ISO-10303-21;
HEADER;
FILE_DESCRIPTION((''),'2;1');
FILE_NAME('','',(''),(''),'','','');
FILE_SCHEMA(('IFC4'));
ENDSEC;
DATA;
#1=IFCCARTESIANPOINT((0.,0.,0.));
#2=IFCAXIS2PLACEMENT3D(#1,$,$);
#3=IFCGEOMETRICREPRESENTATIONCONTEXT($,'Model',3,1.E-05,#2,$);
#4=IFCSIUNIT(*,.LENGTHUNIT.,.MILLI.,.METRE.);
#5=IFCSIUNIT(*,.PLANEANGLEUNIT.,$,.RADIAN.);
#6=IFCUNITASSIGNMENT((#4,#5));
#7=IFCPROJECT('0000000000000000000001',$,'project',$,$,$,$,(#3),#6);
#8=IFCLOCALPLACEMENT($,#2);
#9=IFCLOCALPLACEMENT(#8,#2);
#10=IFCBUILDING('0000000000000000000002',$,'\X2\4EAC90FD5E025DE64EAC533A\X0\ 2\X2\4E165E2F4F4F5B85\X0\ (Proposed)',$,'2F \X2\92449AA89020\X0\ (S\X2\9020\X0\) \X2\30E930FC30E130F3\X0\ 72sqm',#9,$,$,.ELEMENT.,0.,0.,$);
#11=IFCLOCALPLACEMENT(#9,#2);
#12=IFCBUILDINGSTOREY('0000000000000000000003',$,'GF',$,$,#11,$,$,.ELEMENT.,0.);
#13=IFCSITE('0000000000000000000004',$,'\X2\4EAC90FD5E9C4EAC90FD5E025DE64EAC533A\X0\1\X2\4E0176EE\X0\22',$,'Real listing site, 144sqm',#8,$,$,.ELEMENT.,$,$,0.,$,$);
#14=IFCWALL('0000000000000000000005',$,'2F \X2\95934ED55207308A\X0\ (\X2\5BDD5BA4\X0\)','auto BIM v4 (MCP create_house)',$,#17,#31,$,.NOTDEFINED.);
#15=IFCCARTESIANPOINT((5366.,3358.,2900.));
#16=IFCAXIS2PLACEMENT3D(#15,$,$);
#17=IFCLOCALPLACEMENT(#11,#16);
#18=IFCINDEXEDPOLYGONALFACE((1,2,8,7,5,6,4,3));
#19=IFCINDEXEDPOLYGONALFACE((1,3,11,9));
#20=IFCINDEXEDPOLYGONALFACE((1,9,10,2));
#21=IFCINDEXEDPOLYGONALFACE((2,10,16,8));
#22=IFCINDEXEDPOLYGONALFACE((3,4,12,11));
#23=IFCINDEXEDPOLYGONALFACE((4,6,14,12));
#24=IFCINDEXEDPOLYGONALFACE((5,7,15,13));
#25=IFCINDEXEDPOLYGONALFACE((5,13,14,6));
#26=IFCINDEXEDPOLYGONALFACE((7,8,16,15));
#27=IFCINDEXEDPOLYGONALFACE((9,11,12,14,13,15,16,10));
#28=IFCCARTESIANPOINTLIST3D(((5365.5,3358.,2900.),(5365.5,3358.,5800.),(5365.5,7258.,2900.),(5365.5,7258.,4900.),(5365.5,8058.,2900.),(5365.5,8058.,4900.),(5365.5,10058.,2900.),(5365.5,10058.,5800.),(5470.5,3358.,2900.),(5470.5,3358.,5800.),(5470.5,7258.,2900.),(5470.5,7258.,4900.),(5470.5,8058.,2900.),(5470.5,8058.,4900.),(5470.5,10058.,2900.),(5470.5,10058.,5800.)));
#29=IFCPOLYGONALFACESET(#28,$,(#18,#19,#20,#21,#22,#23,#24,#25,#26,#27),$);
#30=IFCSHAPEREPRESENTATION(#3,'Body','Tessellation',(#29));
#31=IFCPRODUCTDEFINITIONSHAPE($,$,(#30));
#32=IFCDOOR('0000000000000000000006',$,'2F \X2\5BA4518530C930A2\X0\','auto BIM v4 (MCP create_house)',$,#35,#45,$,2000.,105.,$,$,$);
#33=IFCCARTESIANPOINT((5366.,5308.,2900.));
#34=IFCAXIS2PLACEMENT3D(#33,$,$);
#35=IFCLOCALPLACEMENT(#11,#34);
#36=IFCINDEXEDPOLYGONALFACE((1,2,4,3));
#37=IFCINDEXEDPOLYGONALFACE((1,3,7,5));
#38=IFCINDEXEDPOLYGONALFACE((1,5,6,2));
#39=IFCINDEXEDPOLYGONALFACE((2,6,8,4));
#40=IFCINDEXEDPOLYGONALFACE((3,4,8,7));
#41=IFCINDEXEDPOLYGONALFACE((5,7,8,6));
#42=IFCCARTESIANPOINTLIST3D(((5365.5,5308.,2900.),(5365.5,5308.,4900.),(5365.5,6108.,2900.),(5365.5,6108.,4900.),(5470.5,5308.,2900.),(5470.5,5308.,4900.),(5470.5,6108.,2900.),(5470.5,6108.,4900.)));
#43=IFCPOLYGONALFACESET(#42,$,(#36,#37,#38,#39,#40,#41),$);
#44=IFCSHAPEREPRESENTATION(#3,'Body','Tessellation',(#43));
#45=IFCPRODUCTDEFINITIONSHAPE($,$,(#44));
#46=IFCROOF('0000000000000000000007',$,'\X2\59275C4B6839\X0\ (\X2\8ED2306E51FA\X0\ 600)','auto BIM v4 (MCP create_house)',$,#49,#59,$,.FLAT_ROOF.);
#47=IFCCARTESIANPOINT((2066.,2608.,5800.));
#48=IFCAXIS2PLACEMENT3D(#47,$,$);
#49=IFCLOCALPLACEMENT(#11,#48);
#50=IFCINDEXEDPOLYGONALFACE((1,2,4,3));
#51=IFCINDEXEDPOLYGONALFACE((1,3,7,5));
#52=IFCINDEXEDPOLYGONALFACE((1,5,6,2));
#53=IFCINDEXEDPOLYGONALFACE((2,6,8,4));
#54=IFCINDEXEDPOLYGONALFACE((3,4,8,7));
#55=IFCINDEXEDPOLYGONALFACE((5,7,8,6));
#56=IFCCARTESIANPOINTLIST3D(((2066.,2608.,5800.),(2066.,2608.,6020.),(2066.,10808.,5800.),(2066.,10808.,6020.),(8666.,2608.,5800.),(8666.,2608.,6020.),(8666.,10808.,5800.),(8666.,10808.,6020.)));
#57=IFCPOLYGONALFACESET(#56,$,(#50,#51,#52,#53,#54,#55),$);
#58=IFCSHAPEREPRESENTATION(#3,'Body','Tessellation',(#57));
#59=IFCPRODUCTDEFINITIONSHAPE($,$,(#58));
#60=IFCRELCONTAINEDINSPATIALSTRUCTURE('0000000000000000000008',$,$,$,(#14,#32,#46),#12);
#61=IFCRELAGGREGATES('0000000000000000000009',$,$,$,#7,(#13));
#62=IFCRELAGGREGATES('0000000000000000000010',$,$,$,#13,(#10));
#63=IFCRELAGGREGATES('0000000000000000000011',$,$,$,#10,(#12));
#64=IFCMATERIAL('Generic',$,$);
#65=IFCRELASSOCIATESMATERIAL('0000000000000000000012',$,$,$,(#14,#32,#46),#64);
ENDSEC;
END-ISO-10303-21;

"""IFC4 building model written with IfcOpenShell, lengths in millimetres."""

from ifc_helpers import new_model, si_unit, frame, frame_2d, origin, place, context, project, spatial, rectangle, extrude, material, element, fill, save


model = new_model("IFC4")

# Units and contexts
model_context = context("Model", 3, precision=1e-05, world=origin())
ifc_project = project(units=[si_unit("LENGTHUNIT", "METRE", prefix="MILLI"), si_unit("PLANEANGLEUNIT", "RADIAN")], contexts=[model_context])

# Site, building, storey
site_placement = place(None, origin())
site = spatial("IfcSite", under=ifc_project, at=site_placement, Name="京都府京都市左京区1丁目22", ObjectType="Real listing site, 144sqm", CompositionType="ELEMENT", RefElevation=0.0)
building_placement = place(site_placement, origin())
building = spatial("IfcBuilding", under=site, at=building_placement, Name="京都市左京区 2世帯住宅 (Proposed)", ObjectType="2F 鉄骨造 (S造) ラーメン 72sqm", CompositionType="ELEMENT", ElevationOfRefHeight=0.0, ElevationOfTerrain=0.0)
storey_placement = place(building_placement, origin())
storey = spatial("IfcBuildingStorey", under=building, at=storey_placement, Name="GF", CompositionType="ELEMENT", Elevation=0.0)

# Shared definitions
ifc_material = material(Name="Generic")

# Wall, opening, door
wall_1_placement = place(storey_placement, frame((5366.0, 3358.0, 2900.0)))
wall_1 = element("IfcWall", 1, at=wall_1_placement, inside=storey, material=ifc_material, Name="2F 間仕切り (寝室)", Description="auto BIM v4 (MCP create_house)", PredefinedType="NOTDEFINED", context=model_context, shape_type="SweptSolid", body=[
    extrude(rectangle(XDim=105.0, YDim=6700.0, at=frame_2d((52.0, 3350.0))), frame((5366.0, 3358.0, 2900.0)), (0.0, 0.0, 1.0), 2900.0),
])
opening_1_placement = place(storey_placement, frame((5366.0, 5308.0, 2900.0)))
opening_1 = element("IfcOpeningElement", 2, at=opening_1_placement, cuts=wall_1, PredefinedType="NOTDEFINED", context=model_context, shape_type="SweptSolid", body=[
    extrude(rectangle(XDim=105.0, YDim=800.0, at=frame_2d((52.0, 400.0))), frame((5366.0, 5308.0, 2900.0)), (0.0, 0.0, 1.0), 2000.0),
])
door_1_placement = place(storey_placement, frame((5366.0, 5308.0, 2900.0)))
door_1 = element("IfcDoor", 3, at=door_1_placement, inside=storey, material=ifc_material, Name="2F 室内ドア", Description="auto BIM v4 (MCP create_house)", OverallHeight=2000.0, OverallWidth=105.0, context=model_context, shape_type="SweptSolid", body=[
    extrude(rectangle(XDim=105.0, YDim=800.0, at=frame_2d((52.0, 400.0))), frame((5366.0, 5308.0, 2900.0)), (0.0, 0.0, 1.0), 2000.0),
])
fill(opening_1, door_1)

# Roof
roof_placement = place(storey_placement, frame((2066.0, 2608.0, 5800.0)))
element("IfcRoof", 4, at=roof_placement, inside=storey, material=ifc_material, Name="大屋根 (軒の出 600)", Description="auto BIM v4 (MCP create_house)", PredefinedType="FLAT_ROOF", context=model_context, shape_type="SweptSolid", body=[
    extrude(rectangle(XDim=6600.0, YDim=8200.0, at=frame_2d((3300.0, 4100.0))), frame((2066.0, 2608.0, 5800.0)), (0.0, 0.0, 1.0), 220.0),
])

save(model, "model.ifc")
